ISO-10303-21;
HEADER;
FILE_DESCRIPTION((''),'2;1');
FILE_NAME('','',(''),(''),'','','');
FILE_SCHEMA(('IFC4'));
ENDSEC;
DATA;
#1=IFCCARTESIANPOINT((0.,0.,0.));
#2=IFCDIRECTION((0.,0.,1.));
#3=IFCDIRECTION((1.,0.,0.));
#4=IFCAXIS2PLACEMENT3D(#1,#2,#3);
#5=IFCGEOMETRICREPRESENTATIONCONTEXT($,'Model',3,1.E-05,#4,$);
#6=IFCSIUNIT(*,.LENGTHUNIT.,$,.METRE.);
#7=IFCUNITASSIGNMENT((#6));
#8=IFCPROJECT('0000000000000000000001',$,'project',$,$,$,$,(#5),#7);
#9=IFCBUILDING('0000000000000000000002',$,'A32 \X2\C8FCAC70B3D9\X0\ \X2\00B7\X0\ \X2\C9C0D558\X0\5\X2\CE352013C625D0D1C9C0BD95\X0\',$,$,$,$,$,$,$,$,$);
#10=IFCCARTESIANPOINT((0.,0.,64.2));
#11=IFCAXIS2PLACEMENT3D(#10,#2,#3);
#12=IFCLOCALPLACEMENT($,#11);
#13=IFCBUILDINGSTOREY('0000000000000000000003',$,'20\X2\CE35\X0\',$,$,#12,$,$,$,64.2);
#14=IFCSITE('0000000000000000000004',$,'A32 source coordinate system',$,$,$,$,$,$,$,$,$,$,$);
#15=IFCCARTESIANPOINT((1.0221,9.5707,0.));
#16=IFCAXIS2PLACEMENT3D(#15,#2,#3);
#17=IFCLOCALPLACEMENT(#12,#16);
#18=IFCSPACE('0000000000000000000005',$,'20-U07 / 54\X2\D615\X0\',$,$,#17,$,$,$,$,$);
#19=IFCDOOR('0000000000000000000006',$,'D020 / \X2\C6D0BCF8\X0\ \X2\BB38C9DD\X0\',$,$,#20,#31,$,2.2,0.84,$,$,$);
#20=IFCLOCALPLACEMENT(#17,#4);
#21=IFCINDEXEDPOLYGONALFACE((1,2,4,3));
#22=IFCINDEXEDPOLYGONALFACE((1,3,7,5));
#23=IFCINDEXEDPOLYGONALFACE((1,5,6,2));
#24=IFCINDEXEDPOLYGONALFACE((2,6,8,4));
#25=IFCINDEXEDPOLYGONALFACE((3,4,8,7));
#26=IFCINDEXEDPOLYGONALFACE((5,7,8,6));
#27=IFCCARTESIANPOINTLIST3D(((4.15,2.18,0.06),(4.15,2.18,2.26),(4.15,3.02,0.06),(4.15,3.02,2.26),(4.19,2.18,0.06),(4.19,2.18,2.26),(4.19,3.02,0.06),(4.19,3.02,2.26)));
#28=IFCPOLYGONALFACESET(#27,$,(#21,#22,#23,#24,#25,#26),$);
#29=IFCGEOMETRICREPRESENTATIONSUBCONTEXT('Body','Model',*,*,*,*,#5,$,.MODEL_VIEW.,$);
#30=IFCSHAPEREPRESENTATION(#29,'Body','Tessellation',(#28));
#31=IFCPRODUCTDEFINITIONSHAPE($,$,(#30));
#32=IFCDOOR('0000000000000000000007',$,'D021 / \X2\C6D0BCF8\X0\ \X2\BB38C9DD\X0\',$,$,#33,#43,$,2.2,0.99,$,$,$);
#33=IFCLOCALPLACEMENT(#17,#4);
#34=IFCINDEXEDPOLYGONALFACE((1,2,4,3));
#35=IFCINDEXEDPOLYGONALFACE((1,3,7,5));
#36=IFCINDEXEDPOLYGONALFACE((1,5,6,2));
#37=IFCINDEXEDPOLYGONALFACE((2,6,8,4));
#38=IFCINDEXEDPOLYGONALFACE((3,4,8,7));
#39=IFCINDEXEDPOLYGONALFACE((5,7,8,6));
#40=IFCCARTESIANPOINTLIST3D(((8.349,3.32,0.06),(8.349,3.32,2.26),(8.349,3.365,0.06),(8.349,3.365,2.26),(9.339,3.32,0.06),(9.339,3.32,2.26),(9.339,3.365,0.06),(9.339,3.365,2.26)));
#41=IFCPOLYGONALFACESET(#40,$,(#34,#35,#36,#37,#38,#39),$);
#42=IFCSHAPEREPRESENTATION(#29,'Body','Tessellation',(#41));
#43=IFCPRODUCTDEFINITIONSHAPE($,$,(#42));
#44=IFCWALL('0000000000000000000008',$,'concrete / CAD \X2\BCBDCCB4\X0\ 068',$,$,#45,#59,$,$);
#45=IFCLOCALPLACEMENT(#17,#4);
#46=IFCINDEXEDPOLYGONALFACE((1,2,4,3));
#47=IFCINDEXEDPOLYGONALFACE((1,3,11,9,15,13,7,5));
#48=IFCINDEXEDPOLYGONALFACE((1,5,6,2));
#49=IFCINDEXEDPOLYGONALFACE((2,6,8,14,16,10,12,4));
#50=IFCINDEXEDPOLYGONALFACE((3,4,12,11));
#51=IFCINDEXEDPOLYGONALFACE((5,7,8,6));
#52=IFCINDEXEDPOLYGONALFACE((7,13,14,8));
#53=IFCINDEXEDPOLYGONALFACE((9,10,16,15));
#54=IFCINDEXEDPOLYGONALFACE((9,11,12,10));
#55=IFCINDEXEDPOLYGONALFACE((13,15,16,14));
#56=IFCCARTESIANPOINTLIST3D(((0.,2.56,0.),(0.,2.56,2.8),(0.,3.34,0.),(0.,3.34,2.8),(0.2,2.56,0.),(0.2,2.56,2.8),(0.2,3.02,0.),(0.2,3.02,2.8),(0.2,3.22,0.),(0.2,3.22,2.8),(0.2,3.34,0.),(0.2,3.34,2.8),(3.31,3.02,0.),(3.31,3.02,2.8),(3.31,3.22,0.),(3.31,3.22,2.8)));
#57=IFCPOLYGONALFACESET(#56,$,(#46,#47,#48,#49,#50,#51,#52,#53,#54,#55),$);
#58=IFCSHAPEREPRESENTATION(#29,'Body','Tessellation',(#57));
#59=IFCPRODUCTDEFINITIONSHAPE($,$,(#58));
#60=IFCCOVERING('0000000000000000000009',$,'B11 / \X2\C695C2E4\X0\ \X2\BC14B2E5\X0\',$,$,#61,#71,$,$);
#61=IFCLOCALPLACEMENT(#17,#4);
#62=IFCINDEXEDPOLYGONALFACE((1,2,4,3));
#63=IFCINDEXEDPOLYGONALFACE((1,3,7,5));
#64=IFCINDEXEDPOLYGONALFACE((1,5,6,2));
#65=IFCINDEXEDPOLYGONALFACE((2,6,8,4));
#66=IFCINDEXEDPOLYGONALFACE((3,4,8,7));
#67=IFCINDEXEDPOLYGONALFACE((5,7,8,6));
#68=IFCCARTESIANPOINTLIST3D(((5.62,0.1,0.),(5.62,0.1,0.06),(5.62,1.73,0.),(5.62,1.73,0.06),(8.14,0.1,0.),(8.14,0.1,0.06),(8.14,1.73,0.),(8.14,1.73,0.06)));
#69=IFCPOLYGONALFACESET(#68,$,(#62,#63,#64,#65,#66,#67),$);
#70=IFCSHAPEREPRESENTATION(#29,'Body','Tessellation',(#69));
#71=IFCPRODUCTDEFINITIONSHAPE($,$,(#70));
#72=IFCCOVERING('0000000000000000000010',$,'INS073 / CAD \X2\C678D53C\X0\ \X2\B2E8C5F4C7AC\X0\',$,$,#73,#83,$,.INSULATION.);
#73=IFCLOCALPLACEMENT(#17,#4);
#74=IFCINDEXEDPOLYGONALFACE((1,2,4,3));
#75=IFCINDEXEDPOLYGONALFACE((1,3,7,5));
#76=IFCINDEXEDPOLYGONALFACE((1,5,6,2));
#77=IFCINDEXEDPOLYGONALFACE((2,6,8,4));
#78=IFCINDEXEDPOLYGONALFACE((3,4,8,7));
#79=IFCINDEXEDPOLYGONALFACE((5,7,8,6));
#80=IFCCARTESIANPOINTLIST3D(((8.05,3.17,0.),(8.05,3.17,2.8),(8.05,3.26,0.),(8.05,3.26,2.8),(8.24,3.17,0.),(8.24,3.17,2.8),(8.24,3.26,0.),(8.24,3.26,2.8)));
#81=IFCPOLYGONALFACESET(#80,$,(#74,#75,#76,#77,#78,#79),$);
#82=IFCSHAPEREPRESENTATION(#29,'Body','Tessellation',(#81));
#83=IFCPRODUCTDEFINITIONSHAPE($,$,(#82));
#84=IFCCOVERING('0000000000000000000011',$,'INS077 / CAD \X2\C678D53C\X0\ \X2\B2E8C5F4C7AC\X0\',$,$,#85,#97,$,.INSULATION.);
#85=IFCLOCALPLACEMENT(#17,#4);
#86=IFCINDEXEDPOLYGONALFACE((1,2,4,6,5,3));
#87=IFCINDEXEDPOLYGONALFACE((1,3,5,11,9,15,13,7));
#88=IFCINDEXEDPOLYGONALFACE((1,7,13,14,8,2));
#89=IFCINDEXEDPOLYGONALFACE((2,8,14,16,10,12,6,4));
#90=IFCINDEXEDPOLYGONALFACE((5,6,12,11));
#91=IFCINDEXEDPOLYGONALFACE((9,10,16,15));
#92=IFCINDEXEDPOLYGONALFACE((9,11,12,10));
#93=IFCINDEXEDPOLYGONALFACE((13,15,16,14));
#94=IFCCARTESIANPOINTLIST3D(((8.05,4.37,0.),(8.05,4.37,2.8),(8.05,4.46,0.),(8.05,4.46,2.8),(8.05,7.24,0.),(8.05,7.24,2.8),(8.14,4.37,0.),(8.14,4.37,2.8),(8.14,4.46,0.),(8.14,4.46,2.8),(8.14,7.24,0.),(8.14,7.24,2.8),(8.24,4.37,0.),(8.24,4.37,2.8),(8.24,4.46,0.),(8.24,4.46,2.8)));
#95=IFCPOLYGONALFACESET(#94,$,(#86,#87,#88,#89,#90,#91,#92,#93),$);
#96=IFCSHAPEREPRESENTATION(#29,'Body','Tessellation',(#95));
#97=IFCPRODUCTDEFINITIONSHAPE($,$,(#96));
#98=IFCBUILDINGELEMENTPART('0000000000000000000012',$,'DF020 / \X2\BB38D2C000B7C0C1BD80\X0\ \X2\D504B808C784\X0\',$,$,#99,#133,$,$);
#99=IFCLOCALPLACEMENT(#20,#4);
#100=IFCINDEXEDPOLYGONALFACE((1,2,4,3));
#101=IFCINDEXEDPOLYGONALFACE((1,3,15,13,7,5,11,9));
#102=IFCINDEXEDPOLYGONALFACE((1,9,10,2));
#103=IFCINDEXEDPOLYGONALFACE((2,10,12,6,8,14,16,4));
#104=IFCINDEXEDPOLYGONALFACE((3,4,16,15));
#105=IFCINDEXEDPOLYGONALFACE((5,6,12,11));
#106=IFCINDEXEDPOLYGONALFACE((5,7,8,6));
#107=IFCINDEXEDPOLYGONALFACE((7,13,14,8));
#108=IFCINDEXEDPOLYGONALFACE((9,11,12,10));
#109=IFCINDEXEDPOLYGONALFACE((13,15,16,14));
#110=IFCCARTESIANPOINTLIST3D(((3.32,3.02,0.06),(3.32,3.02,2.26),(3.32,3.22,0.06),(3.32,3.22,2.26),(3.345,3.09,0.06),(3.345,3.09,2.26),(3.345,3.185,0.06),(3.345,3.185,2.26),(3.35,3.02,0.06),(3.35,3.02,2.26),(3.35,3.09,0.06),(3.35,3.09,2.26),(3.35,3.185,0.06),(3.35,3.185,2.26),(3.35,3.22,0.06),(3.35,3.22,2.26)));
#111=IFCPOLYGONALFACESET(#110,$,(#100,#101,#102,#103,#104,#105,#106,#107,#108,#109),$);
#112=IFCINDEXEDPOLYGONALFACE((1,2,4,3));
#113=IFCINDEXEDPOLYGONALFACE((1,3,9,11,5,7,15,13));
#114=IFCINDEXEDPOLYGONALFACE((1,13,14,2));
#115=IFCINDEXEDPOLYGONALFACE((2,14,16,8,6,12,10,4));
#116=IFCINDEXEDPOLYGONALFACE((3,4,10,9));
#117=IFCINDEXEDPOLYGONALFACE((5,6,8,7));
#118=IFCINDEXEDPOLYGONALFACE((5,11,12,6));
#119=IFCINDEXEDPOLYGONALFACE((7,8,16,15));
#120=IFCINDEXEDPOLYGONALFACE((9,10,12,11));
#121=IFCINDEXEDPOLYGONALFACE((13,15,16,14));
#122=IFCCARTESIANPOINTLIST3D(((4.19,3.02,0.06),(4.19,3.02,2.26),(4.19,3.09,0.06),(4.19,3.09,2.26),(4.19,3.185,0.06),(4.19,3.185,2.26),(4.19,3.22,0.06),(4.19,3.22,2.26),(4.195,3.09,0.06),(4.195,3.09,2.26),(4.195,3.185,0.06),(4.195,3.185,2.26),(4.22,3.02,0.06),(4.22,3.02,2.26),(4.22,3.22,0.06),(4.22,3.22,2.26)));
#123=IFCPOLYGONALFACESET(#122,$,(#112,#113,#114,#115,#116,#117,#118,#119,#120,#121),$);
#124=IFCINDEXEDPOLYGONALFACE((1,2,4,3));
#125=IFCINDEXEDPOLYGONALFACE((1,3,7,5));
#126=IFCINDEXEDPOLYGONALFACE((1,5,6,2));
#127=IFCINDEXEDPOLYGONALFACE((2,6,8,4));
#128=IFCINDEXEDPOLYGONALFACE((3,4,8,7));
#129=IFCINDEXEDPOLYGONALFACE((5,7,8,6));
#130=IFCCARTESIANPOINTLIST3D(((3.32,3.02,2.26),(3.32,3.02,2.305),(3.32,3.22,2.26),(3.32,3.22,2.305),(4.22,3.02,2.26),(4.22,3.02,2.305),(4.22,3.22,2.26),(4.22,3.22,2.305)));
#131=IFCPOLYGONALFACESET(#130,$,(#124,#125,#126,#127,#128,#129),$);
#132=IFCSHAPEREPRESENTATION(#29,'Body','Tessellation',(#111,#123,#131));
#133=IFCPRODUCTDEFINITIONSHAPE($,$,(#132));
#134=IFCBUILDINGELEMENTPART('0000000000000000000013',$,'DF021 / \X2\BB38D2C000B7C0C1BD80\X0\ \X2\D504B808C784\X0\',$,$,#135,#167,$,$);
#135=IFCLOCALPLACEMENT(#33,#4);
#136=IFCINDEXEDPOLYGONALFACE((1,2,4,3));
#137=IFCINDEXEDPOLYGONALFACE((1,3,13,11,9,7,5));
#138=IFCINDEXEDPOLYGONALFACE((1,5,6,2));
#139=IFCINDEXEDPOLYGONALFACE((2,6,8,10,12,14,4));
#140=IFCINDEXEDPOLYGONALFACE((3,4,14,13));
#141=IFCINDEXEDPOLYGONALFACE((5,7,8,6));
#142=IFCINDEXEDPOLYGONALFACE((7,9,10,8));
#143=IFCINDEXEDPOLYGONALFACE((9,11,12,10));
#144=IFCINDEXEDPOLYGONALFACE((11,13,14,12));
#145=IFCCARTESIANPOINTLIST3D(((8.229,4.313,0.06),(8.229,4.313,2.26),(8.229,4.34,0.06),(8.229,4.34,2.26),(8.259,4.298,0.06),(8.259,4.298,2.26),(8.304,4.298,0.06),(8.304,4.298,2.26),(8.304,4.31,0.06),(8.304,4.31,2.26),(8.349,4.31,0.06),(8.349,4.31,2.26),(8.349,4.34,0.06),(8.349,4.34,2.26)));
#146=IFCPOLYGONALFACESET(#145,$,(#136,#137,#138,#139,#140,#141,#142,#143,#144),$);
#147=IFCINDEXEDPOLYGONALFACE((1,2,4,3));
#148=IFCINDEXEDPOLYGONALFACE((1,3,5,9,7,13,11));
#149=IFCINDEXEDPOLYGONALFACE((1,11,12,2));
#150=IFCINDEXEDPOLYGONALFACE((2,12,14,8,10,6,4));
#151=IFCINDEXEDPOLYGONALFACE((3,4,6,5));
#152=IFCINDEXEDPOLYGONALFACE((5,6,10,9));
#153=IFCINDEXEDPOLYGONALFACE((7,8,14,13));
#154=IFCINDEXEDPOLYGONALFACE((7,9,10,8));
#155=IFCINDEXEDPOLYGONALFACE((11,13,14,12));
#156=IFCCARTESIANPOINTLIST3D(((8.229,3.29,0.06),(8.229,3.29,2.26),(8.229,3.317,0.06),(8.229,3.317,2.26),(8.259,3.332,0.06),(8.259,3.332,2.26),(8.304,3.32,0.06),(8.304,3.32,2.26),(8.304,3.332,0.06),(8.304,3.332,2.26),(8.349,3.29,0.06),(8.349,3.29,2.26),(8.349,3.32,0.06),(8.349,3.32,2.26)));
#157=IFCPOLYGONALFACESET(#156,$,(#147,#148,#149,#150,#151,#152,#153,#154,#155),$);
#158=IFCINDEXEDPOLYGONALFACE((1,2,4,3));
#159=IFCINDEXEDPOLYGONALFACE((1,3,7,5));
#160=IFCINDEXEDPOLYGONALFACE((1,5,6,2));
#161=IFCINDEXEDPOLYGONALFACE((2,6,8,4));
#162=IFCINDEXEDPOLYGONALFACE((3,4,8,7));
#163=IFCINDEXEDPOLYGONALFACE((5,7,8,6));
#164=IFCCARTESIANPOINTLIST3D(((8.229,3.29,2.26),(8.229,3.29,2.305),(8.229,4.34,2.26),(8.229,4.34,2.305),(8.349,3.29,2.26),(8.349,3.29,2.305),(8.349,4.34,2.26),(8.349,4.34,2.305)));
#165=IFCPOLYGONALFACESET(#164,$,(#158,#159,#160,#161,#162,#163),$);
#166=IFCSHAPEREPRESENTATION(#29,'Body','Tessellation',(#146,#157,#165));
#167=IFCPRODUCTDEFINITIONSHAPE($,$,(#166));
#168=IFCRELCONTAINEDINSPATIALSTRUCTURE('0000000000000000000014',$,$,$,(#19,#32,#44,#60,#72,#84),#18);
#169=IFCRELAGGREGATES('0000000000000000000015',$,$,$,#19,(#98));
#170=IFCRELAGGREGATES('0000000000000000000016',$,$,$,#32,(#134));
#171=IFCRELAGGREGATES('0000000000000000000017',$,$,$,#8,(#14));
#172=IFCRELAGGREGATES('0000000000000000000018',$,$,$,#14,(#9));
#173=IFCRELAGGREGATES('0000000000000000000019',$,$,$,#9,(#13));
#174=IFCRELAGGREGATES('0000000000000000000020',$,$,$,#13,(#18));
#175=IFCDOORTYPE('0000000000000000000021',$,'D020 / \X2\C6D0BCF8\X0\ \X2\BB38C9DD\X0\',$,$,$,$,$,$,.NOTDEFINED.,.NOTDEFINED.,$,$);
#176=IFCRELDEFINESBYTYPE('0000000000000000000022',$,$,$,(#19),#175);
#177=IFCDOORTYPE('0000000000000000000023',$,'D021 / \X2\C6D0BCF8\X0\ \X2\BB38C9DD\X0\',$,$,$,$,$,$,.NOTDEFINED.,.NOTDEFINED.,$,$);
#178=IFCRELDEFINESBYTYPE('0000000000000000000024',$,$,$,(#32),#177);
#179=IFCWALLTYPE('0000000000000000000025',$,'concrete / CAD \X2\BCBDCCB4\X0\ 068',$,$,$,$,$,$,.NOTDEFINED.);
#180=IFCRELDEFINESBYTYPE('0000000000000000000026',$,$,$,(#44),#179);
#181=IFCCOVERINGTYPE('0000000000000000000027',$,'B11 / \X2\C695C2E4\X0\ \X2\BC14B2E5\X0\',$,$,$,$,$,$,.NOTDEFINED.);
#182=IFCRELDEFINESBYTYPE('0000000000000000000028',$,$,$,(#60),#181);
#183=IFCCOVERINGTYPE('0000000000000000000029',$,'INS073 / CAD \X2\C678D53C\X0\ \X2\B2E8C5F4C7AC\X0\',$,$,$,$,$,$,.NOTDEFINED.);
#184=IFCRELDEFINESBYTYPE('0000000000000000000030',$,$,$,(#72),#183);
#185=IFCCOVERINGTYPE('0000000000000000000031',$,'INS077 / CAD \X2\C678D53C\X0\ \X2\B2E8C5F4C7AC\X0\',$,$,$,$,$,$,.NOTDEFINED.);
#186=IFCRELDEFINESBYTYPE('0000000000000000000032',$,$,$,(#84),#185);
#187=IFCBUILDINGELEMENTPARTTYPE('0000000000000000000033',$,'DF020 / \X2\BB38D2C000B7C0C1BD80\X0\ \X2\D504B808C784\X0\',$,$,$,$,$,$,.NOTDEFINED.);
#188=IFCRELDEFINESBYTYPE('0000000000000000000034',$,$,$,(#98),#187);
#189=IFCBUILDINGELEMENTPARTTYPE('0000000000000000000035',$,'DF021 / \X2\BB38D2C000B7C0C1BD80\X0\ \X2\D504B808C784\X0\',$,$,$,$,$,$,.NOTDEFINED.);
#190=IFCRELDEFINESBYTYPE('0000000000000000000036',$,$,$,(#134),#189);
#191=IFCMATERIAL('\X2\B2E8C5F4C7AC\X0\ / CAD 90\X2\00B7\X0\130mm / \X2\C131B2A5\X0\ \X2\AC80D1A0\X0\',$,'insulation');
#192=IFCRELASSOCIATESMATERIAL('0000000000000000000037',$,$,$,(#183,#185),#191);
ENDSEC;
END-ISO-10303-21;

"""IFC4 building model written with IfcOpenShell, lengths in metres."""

from ifc_helpers import new_model, si_unit, frame, origin, origin_with_axes, place, context, subcontext, project, spatial, polyline, outline, extrude, source, transform, mapped, material, type_object, type_shapes, element, aggregate, save


model = new_model("IFC4")

# Units and contexts
model_context = context("Model", 3, precision=1e-05, world=origin_with_axes())
body_context = subcontext(model_context, "Body", "Model", "MODEL_VIEW")
ifc_project = project(units=[si_unit("LENGTHUNIT", "METRE")], contexts=[model_context])

# Site, building, storey, space
storey_placement = place(None, frame((0.0, 0.0, 64.2), z_axis=(0.0, 0.0, 1.0), x_axis=(1.0, 0.0, 0.0)))
space_placement = place(storey_placement, frame((1.0221, 9.5707, 0.0), z_axis=(0.0, 0.0, 1.0), x_axis=(1.0, 0.0, 0.0)))
site = spatial("IfcSite", under=ifc_project, Name="A32 source coordinate system")
building = spatial("IfcBuilding", under=site, Name="A32 주거동 · 지하5층–옥탑지붕")
storey = spatial("IfcBuildingStorey", under=building, at=storey_placement, Name="20층", Elevation=64.2)
space = spatial("IfcSpace", under=storey, at=space_placement, Name="20-U07 / 54형")

# Doors
door_type_1 = type_object("IfcDoorType", Name="D020 / 원본 문짝", OperationType="NOTDEFINED", PredefinedType="NOTDEFINED")
shared_shape_1 = source(origin(), body_context, "Body", "SweptSolid", [
    extrude(outline(polyline([(4.19, 3.02), (4.19, 2.18), (4.15, 2.18), (4.15, 3.02), (4.19, 3.02)])), frame((0.0, 0.0, 0.06)), (0.0, 0.0, 1.0), 2.2),
])
type_shapes(door_type_1, [shared_shape_1])
door_1_placement = place(space_placement, origin_with_axes())
door_1 = element("IfcDoor", 1, at=door_1_placement, inside=space, type_object=door_type_1, Name="D020 / 원본 문짝", OverallHeight=2.2, OverallWidth=0.84, context=body_context, shape_type="MappedRepresentation", body=[
    mapped(shared_shape_1, transform((0.0, 0.0, 0.0), scale=1.0)),
])
door_type_2 = type_object("IfcDoorType", Name="D021 / 원본 문짝", OperationType="NOTDEFINED", PredefinedType="NOTDEFINED")
shared_shape_2 = source(origin(), body_context, "Body", "SweptSolid", [
    extrude(outline(polyline([(9.339, 3.365), (9.339, 3.32), (8.349, 3.32), (8.349, 3.365), (9.339, 3.365)])), frame((0.0, 0.0, 0.06)), (0.0, 0.0, 1.0), 2.2),
])
type_shapes(door_type_2, [shared_shape_2])
door_2_placement = place(space_placement, origin_with_axes())
door_2 = element("IfcDoor", 2, at=door_2_placement, inside=space, type_object=door_type_2, Name="D021 / 원본 문짝", OverallHeight=2.2, OverallWidth=0.99, context=body_context, shape_type="MappedRepresentation", body=[
    mapped(shared_shape_2, transform((0.0, 0.0, 0.0), scale=1.0)),
])

# Wall
wall_type_1 = type_object("IfcWallType", Name="concrete / CAD 벽체 068", PredefinedType="NOTDEFINED")
shared_shape_3 = source(origin(), body_context, "Body", "SweptSolid", [
    extrude(outline(polyline([(0.2, 3.02), (0.2, 2.56), (0.0, 2.56), (0.0, 3.34), (0.2, 3.34), (0.2, 3.22), (3.31, 3.22), (3.31, 3.02), (0.2, 3.02)])), origin(), (0.0, 0.0, 1.0), 2.8),
])
type_shapes(wall_type_1, [shared_shape_3])
wall_1_placement = place(space_placement, origin_with_axes())
element("IfcWall", 3, at=wall_1_placement, inside=space, type_object=wall_type_1, Name="concrete / CAD 벽체 068", context=body_context, shape_type="MappedRepresentation", body=[
    mapped(shared_shape_3, transform((0.0, 0.0, 0.0), scale=1.0)),
])

# Coverings
covering_type_1 = type_object("IfcCoveringType", Name="B11 / 욕실 바닥", PredefinedType="NOTDEFINED")
shared_shape_4 = source(origin(), body_context, "Body", "SweptSolid", [
    extrude(outline(polyline([(8.14, 1.73), (8.14, 0.1), (5.62, 0.1), (5.62, 1.73), (8.14, 1.73)])), origin(), (0.0, 0.0, 1.0), 0.06),
])
type_shapes(covering_type_1, [shared_shape_4])
covering_1_placement = place(space_placement, origin_with_axes())
element("IfcCovering", 4, at=covering_1_placement, inside=space, type_object=covering_type_1, Name="B11 / 욕실 바닥", context=body_context, shape_type="MappedRepresentation", body=[
    mapped(shared_shape_4, transform((0.0, 0.0, 0.0), scale=1.0)),
])
ifc_material = material(Name="단열재 / CAD 90·130mm / 성능 검토", Category="insulation")
covering_type_2 = type_object("IfcCoveringType", Name="INS073 / CAD 외피 단열재", PredefinedType="NOTDEFINED", material=ifc_material)
shared_shape_5 = source(origin(), body_context, "Body", "SweptSolid", [
    extrude(outline(polyline([(8.05, 3.17), (8.05, 3.26), (8.24, 3.26), (8.24, 3.17), (8.05, 3.17)])), origin(), (0.0, 0.0, 1.0), 2.8),
])
type_shapes(covering_type_2, [shared_shape_5])
covering_2_placement = place(space_placement, origin_with_axes())
element("IfcCovering", 5, at=covering_2_placement, inside=space, type_object=covering_type_2, Name="INS073 / CAD 외피 단열재", PredefinedType="INSULATION", context=body_context, shape_type="MappedRepresentation", body=[
    mapped(shared_shape_5, transform((0.0, 0.0, 0.0), scale=1.0)),
])
covering_type_3 = type_object("IfcCoveringType", Name="INS077 / CAD 외피 단열재", PredefinedType="NOTDEFINED", material=ifc_material)
shared_shape_6 = source(origin(), body_context, "Body", "SweptSolid", [
    extrude(outline(polyline([(8.24, 4.37), (8.14, 4.37), (8.05, 4.37), (8.05, 4.46), (8.05, 7.24), (8.14, 7.24), (8.14, 4.46), (8.24, 4.46), (8.24, 4.37)])), origin(), (0.0, 0.0, 1.0), 2.8),
])
type_shapes(covering_type_3, [shared_shape_6])
covering_3_placement = place(space_placement, origin_with_axes())
element("IfcCovering", 6, at=covering_3_placement, inside=space, type_object=covering_type_3, Name="INS077 / CAD 외피 단열재", PredefinedType="INSULATION", context=body_context, shape_type="MappedRepresentation", body=[
    mapped(shared_shape_6, transform((0.0, 0.0, 0.0), scale=1.0)),
])

# Building element parts
building_element_part_type_1 = type_object("IfcBuildingElementPartType", Name="DF020 / 문틀·상부 프레임", PredefinedType="NOTDEFINED")
shared_shape_7 = source(origin(), body_context, "Body", "SweptSolid", [
    extrude(outline(polyline([(3.32, 3.22), (3.35, 3.22), (3.35, 3.185), (3.345, 3.185), (3.345, 3.09), (3.35, 3.09), (3.35, 3.02), (3.32, 3.02), (3.32, 3.22)])), frame((0.0, 0.0, 0.06)), (0.0, 0.0, 1.0), 2.2),
    extrude(outline(polyline([(4.19, 3.02), (4.19, 3.09), (4.195, 3.09), (4.195, 3.185), (4.19, 3.185), (4.19, 3.22), (4.22, 3.22), (4.22, 3.02), (4.19, 3.02)])), frame((0.0, 0.0, 0.06)), (0.0, 0.0, 1.0), 2.2),
    extrude(outline(polyline([(3.32, 3.02), (3.32, 3.22), (4.22, 3.22), (4.22, 3.02), (3.32, 3.02)])), frame((0.0, 0.0, 2.26)), (0.0, 0.0, 1.0), 0.045),
])
type_shapes(building_element_part_type_1, [shared_shape_7])
building_element_part_1_placement = place(door_1_placement, origin_with_axes())
building_element_part_1 = element("IfcBuildingElementPart", 7, at=building_element_part_1_placement, type_object=building_element_part_type_1, Name="DF020 / 문틀·상부 프레임", context=body_context, shape_type="MappedRepresentation", body=[
    mapped(shared_shape_7, transform((0.0, 0.0, 0.0), scale=1.0)),
])
aggregate(door_1, [building_element_part_1])
building_element_part_type_2 = type_object("IfcBuildingElementPartType", Name="DF021 / 문틀·상부 프레임", PredefinedType="NOTDEFINED")
shared_shape_8 = source(origin(), body_context, "Body", "SweptSolid", [
    extrude(outline(polyline([(8.349, 4.31), (8.304, 4.31), (8.304, 4.298), (8.259, 4.298), (8.229, 4.313), (8.229, 4.34), (8.349, 4.34), (8.349, 4.31)])), frame((0.0, 0.0, 0.06)), (0.0, 0.0, 1.0), 2.2),
    extrude(outline(polyline([(8.229, 3.29), (8.229, 3.317), (8.259, 3.332), (8.304, 3.332), (8.304, 3.32), (8.349, 3.32), (8.349, 3.29), (8.229, 3.29)])), frame((0.0, 0.0, 0.06)), (0.0, 0.0, 1.0), 2.2),
    extrude(outline(polyline([(8.229, 3.29), (8.229, 4.34), (8.349, 4.34), (8.349, 3.29), (8.229, 3.29)])), frame((0.0, 0.0, 2.26)), (0.0, 0.0, 1.0), 0.045),
])
type_shapes(building_element_part_type_2, [shared_shape_8])
building_element_part_2_placement = place(door_2_placement, origin_with_axes())
building_element_part_2 = element("IfcBuildingElementPart", 8, at=building_element_part_2_placement, type_object=building_element_part_type_2, Name="DF021 / 문틀·상부 프레임", context=body_context, shape_type="MappedRepresentation", body=[
    mapped(shared_shape_8, transform((0.0, 0.0, 0.0), scale=1.0)),
])
aggregate(door_2, [building_element_part_2])

save(model, "model.ifc")
